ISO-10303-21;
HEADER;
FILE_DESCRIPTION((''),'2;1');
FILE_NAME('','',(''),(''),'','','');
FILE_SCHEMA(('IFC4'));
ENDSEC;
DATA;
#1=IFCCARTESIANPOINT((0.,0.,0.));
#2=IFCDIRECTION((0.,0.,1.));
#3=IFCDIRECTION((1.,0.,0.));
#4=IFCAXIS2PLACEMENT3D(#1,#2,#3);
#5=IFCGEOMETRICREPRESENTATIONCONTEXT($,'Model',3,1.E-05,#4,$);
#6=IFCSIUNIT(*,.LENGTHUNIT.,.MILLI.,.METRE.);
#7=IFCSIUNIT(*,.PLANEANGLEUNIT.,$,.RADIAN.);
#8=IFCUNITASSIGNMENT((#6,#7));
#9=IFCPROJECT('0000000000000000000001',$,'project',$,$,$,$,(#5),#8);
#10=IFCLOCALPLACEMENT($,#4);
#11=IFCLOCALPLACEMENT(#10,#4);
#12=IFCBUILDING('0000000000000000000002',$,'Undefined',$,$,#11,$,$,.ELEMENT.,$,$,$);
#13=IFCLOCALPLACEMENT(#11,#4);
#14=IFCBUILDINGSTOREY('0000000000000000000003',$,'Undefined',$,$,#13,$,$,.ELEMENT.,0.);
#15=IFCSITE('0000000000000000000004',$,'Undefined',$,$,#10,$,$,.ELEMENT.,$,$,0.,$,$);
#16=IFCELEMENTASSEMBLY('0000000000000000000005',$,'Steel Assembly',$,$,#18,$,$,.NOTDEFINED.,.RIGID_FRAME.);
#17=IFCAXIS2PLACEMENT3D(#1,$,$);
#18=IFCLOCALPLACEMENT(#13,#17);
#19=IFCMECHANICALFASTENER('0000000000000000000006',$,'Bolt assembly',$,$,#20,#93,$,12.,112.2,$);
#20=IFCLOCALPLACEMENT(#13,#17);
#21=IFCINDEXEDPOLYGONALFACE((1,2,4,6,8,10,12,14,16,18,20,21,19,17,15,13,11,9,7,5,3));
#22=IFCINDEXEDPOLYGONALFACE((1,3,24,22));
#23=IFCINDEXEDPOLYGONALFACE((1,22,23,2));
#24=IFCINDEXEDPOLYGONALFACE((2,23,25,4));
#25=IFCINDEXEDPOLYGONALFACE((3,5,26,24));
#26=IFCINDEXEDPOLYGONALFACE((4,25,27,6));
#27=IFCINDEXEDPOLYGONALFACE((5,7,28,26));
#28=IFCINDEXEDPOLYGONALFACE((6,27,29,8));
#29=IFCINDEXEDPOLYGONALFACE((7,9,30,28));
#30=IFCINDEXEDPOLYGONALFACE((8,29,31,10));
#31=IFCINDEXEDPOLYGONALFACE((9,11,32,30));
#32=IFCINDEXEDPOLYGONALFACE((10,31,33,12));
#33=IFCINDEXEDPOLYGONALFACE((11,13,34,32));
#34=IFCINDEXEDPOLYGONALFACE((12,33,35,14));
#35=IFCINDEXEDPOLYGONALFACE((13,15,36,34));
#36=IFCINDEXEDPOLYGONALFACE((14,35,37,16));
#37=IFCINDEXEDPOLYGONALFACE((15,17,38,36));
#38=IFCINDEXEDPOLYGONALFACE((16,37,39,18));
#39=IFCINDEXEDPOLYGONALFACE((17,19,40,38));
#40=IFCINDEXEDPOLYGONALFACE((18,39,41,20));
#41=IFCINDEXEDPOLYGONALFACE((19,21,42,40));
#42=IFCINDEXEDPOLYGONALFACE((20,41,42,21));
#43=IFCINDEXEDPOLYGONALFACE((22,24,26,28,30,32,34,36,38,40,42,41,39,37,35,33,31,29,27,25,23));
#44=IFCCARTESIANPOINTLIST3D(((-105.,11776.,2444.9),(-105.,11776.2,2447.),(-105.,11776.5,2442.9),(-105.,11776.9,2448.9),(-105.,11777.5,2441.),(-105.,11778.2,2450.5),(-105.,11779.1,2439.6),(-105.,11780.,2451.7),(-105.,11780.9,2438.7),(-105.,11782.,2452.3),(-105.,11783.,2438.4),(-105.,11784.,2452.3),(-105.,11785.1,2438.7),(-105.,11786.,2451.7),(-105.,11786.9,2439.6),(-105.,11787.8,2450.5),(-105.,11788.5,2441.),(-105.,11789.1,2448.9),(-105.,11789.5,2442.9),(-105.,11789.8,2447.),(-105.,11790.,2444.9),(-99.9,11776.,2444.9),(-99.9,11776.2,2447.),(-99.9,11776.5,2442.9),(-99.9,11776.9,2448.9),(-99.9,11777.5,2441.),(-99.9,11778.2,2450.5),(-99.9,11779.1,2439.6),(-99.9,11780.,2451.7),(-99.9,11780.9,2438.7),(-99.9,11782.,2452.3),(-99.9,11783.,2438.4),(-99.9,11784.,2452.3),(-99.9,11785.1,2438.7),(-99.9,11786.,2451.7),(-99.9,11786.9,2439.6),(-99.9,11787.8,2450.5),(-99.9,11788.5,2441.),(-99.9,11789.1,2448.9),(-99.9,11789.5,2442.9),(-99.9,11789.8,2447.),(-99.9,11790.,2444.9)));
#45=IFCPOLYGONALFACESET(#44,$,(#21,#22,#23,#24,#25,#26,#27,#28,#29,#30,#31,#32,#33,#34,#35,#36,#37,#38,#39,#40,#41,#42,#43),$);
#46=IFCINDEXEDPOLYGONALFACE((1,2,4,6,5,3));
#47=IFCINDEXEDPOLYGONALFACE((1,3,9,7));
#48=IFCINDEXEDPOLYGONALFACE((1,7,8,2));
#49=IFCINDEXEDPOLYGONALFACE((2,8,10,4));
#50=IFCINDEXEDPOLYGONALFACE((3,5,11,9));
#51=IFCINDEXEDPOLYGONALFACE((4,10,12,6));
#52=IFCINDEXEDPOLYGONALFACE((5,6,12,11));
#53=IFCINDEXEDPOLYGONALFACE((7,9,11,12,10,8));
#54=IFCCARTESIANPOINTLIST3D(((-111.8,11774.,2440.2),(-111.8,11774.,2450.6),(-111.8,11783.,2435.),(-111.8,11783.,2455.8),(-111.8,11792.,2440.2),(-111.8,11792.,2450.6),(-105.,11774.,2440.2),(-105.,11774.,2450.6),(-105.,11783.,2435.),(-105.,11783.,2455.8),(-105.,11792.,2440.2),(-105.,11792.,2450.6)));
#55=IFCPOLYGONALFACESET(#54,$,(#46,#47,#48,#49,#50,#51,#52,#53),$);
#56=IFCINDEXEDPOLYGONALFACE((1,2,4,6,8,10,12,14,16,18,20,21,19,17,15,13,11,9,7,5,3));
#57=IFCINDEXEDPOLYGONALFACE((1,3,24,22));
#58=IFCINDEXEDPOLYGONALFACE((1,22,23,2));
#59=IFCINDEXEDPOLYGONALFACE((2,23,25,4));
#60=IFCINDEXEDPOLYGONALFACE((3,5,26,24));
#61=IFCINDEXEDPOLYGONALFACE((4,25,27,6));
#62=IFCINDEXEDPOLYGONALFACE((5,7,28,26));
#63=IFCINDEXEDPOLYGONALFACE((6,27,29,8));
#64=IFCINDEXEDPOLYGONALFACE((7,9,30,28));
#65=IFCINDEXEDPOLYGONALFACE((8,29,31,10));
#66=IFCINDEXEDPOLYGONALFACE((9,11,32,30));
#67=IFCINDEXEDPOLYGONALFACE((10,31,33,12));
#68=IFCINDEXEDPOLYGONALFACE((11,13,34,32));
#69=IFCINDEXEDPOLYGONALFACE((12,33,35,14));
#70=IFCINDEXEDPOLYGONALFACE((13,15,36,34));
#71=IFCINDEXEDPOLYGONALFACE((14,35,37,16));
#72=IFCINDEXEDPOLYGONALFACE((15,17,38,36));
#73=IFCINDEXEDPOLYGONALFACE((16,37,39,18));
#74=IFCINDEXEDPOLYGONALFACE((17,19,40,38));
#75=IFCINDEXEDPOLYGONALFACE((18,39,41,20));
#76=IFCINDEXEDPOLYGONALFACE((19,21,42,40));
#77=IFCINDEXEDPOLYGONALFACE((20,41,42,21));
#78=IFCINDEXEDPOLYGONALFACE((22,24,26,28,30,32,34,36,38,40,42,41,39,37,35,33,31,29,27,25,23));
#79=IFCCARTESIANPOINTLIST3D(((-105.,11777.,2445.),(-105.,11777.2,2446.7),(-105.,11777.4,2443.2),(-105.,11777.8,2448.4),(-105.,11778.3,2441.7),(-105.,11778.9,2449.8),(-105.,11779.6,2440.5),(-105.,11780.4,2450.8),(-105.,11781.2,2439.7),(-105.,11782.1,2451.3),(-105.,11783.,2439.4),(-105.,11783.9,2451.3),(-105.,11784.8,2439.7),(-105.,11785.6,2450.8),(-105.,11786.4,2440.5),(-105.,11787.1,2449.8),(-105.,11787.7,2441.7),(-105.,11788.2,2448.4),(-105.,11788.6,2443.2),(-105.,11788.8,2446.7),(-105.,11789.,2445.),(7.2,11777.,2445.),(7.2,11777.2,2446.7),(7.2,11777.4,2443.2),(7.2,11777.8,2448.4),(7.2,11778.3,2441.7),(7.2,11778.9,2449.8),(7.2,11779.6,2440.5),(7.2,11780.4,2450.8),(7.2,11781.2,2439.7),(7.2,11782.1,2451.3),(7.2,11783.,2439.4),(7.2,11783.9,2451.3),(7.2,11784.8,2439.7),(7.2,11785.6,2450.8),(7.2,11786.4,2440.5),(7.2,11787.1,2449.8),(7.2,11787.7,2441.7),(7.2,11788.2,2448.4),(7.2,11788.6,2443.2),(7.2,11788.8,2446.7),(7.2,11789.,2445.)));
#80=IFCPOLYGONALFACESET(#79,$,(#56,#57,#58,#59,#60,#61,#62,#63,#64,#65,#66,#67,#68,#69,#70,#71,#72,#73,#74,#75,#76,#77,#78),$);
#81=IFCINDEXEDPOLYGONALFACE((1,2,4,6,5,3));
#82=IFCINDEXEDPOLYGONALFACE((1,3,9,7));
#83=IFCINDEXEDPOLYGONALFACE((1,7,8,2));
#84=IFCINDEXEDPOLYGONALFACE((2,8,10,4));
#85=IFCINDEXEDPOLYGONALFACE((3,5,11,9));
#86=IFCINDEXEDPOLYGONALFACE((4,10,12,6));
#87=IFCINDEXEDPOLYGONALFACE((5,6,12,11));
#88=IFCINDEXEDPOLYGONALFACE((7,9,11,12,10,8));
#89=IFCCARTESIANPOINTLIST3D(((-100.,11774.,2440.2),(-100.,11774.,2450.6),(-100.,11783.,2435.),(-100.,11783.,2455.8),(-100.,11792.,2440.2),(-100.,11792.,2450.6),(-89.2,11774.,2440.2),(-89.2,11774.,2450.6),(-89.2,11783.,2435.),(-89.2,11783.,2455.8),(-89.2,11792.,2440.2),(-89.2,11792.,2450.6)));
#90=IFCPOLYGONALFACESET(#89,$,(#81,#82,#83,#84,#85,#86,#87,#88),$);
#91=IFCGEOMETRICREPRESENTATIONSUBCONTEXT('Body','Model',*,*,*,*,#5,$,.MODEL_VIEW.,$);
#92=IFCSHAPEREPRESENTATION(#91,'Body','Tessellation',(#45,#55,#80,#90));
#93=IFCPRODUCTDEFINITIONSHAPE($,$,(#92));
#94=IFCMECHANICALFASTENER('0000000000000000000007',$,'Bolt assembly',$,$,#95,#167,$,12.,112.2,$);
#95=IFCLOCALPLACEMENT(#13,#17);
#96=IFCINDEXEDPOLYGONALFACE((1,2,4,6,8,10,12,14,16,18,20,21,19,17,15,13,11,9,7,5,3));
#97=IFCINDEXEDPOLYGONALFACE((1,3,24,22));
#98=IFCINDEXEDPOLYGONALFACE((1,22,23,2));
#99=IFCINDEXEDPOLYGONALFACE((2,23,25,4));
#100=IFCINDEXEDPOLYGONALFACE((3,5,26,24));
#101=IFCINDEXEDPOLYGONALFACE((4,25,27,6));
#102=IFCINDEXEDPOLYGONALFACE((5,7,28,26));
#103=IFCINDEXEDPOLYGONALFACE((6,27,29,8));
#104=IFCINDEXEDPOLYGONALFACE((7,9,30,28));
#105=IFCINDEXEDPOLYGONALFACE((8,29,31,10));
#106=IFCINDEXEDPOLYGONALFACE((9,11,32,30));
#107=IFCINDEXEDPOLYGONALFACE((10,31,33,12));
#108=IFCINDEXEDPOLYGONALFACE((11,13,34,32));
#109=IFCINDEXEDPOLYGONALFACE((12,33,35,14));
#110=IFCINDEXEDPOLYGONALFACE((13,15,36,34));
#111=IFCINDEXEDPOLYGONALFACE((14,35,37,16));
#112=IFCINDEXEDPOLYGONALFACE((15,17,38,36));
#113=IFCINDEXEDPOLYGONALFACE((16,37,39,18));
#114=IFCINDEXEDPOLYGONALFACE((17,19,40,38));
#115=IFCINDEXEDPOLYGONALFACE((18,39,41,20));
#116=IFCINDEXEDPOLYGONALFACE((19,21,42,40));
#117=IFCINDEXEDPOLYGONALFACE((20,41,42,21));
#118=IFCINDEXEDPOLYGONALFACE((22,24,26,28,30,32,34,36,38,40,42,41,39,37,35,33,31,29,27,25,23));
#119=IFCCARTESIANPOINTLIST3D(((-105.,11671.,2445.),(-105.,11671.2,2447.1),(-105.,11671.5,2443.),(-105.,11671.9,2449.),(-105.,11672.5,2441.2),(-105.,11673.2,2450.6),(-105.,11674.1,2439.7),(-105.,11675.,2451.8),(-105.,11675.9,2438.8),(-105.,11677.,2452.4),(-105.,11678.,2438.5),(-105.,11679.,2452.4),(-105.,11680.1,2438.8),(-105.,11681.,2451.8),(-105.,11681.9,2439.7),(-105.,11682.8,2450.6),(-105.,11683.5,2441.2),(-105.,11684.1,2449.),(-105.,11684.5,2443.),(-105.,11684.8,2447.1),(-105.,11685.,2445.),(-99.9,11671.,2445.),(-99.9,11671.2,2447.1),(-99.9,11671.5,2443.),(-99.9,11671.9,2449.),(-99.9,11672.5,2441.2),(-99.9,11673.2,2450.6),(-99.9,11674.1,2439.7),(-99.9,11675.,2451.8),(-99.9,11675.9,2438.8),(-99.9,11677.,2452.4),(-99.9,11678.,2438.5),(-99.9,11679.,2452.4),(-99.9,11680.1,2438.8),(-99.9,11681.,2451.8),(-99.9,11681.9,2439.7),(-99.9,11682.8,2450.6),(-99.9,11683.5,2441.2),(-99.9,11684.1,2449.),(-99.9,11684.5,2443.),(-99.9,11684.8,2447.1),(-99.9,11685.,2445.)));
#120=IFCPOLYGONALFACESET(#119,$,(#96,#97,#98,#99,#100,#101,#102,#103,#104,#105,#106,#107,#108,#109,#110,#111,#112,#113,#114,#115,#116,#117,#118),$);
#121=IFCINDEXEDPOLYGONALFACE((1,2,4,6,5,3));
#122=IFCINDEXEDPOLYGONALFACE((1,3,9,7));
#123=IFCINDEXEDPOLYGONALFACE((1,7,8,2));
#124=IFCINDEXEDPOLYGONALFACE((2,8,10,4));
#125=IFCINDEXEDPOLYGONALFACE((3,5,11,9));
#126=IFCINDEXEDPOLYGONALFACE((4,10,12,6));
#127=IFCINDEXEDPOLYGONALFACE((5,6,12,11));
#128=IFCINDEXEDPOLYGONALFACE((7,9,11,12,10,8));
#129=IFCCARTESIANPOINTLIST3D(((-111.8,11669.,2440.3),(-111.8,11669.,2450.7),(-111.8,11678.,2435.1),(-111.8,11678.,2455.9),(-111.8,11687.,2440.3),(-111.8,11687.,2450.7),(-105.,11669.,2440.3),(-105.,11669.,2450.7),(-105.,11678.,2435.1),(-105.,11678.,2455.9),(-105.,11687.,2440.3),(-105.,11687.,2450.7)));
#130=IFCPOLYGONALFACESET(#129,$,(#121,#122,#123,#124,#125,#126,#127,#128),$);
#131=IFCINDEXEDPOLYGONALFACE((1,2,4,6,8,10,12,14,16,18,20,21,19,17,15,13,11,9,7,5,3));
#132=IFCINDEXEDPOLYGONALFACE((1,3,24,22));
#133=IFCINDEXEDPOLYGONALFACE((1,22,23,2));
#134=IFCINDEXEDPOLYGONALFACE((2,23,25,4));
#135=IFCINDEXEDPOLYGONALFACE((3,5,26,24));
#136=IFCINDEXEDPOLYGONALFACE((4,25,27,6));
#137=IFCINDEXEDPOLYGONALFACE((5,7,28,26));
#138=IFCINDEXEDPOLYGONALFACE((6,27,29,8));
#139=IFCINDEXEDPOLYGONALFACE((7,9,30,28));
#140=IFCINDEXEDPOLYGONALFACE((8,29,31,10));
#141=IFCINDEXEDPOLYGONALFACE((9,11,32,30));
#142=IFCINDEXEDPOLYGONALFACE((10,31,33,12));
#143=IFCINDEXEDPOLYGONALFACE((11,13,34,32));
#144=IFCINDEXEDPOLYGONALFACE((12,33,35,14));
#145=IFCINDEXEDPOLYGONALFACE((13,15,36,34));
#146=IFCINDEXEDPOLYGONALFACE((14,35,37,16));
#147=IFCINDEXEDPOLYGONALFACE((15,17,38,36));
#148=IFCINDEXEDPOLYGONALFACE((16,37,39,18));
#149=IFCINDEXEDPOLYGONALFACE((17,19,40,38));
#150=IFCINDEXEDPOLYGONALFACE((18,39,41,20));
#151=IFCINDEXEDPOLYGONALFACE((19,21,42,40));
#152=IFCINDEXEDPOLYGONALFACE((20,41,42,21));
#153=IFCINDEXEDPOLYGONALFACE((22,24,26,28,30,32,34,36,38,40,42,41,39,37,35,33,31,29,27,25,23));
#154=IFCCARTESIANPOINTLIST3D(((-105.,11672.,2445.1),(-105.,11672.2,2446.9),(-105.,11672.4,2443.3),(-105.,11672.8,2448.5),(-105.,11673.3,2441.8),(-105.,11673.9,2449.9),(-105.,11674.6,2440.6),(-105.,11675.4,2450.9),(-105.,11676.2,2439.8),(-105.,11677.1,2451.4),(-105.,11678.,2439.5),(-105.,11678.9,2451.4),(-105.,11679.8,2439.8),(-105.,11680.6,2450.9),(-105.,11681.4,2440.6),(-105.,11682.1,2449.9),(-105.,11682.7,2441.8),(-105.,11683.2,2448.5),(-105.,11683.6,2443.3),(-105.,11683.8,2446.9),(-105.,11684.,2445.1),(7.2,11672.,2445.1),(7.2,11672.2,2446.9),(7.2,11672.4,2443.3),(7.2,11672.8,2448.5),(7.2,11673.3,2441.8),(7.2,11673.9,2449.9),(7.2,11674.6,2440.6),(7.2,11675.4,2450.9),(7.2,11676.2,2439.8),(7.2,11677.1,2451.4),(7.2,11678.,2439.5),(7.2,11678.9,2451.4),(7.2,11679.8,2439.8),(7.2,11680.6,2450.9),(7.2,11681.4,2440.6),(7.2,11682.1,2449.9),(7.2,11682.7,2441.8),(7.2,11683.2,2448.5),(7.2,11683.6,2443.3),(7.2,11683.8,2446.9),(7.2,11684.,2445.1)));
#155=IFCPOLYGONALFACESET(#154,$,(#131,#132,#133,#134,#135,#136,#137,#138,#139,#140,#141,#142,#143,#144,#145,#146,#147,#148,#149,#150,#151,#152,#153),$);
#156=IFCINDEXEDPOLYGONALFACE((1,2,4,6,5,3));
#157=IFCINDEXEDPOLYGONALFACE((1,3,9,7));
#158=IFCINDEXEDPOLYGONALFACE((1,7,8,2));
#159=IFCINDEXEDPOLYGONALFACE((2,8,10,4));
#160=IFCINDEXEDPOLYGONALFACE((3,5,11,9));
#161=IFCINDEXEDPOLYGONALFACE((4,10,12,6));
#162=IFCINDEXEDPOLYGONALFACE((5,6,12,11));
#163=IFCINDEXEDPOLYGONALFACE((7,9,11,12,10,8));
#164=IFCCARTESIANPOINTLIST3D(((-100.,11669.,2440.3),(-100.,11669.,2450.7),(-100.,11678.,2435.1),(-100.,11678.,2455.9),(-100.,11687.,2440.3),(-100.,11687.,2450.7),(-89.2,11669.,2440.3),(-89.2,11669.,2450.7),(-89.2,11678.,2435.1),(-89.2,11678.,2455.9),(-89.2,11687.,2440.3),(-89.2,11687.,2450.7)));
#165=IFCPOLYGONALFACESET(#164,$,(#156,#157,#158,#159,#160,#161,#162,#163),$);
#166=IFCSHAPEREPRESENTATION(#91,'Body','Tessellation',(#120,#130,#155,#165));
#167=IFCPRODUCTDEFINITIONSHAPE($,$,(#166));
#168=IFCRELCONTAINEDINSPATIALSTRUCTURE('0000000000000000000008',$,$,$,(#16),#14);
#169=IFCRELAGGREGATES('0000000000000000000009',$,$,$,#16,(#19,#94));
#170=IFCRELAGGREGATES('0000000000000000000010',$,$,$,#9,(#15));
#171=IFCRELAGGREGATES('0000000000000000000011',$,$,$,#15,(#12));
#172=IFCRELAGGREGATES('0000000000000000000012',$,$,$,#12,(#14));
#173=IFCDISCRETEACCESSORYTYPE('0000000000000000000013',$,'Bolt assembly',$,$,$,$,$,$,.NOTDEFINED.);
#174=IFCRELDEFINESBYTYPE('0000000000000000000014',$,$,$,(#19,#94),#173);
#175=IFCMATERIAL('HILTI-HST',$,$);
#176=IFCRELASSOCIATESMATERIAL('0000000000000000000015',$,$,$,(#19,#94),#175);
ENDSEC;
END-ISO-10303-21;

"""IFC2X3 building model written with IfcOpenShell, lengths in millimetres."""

from ifc_helpers import new_model, si_unit, frame, origin_with_axes, origin_2d_with_axis, place, context, subcontext, project, spatial, polyline, circle, outline, extrude, source, transform, mapped, material, type_object, element, aggregate, save


model = new_model("IFC2X3")

# Units and contexts
model_context = context("Model", 3, precision=1e-05, world=origin_with_axes())
body_context = subcontext(model_context, "Body", "Model", "MODEL_VIEW")
ifc_project = project(units=[si_unit("LENGTHUNIT", "METRE", prefix="MILLI"), si_unit("PLANEANGLEUNIT", "RADIAN")], contexts=[model_context])

# Site, building, storey
site_placement = place(None, origin_with_axes())
site = spatial("IfcSite", under=ifc_project, at=site_placement, Name="Undefined", CompositionType="ELEMENT", RefElevation=0.0)
building_placement = place(site_placement, origin_with_axes())
building = spatial("IfcBuilding", under=site, at=building_placement, Name="Undefined", CompositionType="ELEMENT")
storey_placement = place(building_placement, origin_with_axes())
storey = spatial("IfcBuildingStorey", under=building, at=storey_placement, Name="Undefined", CompositionType="ELEMENT", Elevation=0.0)

# Element assembly
assembly_1_placement = place(storey_placement, origin_with_axes())
assembly_1 = element("IfcElementAssembly", 1, at=assembly_1_placement, inside=storey, Name="Steel Assembly", AssemblyPlace="NOTDEFINED", PredefinedType="RIGID_FRAME")

# Shared definitions
discrete_accessory_type_1 = type_object("IfcDiscreteAccessoryType", Name="Bolt assembly")

# Mechanical fasteners
ifc_material_1 = material(Name="HILTI-HST")
shared_shape_1 = source(origin_with_axes(), body_context, "Body", "SweptSolid", [
    extrude(circle(Radius=7.0, at=origin_2d_with_axis()), frame((0.0, -5.0, 0.0), z_axis=(0.0, 1.0, 0.0), x_axis=(1.0, 0.0, 0.0)), (0.0, 0.0, 1.0), 5.1),
    extrude(outline(polyline([(10.4, 0.0), (5.2, 9.0), (-5.2, 9.0), (-10.4, 0.0), (-5.2, -9.0), (5.2, -9.0), (10.4, 0.0)])), frame((0.0, -11.8, 0.0), z_axis=(0.0, 1.0, 0.0), x_axis=(1.0, 0.0, 0.0)), (0.0, 0.0, 1.0), 6.8),
    extrude(circle(Radius=6.0, at=origin_2d_with_axis()), frame((0.0, -5.0, 0.0), z_axis=(0.0, 1.0, 0.0), x_axis=(1.0, 0.0, 0.0)), (0.0, 0.0, 1.0), 112.2),
    extrude(outline(polyline([(10.4, 0.0), (5.2, 9.0), (-5.2, 9.0), (-10.4, 0.0), (-5.2, -9.0), (5.2, -9.0), (10.4, 0.0)])), frame((0.0, 0.0, 0.0), z_axis=(0.0, 1.0, 0.0), x_axis=(1.0, 0.0, 0.0)), (0.0, 0.0, 1.0), 10.8),
])
mechanical_fastener_1_placement = place(assembly_1_placement, frame((-100.0, 11783.0, 2445.4), z_axis=(0.0, -1.0, 0.0), x_axis=(0.0, 0.0, -1.0)))
mechanical_fastener_1 = element("IfcMechanicalFastener", 2, at=mechanical_fastener_1_placement, type_object=discrete_accessory_type_1, material=ifc_material_1, Name="Bolt assembly", NominalDiameter=12.0, NominalLength=112.2, context=body_context, shape_type="MappedRepresentation", body=[
    mapped(shared_shape_1, transform((0.0, 0.0, 0.0))),
])
mechanical_fastener_2_placement = place(assembly_1_placement, frame((-100.0, 11678.0, 2445.5), z_axis=(0.0, -1.0, 0.0), x_axis=(0.0, 0.0, -1.0)))
mechanical_fastener_2 = element("IfcMechanicalFastener", 3, at=mechanical_fastener_2_placement, type_object=discrete_accessory_type_1, material=ifc_material_1, Name="Bolt assembly", NominalDiameter=12.0, NominalLength=112.2, context=body_context, shape_type="MappedRepresentation", body=[
    mapped(shared_shape_1, transform((0.0, 0.0, 0.0))),
])
aggregate(assembly_1, [mechanical_fastener_1, mechanical_fastener_2])

save(model, "model.ifc")
